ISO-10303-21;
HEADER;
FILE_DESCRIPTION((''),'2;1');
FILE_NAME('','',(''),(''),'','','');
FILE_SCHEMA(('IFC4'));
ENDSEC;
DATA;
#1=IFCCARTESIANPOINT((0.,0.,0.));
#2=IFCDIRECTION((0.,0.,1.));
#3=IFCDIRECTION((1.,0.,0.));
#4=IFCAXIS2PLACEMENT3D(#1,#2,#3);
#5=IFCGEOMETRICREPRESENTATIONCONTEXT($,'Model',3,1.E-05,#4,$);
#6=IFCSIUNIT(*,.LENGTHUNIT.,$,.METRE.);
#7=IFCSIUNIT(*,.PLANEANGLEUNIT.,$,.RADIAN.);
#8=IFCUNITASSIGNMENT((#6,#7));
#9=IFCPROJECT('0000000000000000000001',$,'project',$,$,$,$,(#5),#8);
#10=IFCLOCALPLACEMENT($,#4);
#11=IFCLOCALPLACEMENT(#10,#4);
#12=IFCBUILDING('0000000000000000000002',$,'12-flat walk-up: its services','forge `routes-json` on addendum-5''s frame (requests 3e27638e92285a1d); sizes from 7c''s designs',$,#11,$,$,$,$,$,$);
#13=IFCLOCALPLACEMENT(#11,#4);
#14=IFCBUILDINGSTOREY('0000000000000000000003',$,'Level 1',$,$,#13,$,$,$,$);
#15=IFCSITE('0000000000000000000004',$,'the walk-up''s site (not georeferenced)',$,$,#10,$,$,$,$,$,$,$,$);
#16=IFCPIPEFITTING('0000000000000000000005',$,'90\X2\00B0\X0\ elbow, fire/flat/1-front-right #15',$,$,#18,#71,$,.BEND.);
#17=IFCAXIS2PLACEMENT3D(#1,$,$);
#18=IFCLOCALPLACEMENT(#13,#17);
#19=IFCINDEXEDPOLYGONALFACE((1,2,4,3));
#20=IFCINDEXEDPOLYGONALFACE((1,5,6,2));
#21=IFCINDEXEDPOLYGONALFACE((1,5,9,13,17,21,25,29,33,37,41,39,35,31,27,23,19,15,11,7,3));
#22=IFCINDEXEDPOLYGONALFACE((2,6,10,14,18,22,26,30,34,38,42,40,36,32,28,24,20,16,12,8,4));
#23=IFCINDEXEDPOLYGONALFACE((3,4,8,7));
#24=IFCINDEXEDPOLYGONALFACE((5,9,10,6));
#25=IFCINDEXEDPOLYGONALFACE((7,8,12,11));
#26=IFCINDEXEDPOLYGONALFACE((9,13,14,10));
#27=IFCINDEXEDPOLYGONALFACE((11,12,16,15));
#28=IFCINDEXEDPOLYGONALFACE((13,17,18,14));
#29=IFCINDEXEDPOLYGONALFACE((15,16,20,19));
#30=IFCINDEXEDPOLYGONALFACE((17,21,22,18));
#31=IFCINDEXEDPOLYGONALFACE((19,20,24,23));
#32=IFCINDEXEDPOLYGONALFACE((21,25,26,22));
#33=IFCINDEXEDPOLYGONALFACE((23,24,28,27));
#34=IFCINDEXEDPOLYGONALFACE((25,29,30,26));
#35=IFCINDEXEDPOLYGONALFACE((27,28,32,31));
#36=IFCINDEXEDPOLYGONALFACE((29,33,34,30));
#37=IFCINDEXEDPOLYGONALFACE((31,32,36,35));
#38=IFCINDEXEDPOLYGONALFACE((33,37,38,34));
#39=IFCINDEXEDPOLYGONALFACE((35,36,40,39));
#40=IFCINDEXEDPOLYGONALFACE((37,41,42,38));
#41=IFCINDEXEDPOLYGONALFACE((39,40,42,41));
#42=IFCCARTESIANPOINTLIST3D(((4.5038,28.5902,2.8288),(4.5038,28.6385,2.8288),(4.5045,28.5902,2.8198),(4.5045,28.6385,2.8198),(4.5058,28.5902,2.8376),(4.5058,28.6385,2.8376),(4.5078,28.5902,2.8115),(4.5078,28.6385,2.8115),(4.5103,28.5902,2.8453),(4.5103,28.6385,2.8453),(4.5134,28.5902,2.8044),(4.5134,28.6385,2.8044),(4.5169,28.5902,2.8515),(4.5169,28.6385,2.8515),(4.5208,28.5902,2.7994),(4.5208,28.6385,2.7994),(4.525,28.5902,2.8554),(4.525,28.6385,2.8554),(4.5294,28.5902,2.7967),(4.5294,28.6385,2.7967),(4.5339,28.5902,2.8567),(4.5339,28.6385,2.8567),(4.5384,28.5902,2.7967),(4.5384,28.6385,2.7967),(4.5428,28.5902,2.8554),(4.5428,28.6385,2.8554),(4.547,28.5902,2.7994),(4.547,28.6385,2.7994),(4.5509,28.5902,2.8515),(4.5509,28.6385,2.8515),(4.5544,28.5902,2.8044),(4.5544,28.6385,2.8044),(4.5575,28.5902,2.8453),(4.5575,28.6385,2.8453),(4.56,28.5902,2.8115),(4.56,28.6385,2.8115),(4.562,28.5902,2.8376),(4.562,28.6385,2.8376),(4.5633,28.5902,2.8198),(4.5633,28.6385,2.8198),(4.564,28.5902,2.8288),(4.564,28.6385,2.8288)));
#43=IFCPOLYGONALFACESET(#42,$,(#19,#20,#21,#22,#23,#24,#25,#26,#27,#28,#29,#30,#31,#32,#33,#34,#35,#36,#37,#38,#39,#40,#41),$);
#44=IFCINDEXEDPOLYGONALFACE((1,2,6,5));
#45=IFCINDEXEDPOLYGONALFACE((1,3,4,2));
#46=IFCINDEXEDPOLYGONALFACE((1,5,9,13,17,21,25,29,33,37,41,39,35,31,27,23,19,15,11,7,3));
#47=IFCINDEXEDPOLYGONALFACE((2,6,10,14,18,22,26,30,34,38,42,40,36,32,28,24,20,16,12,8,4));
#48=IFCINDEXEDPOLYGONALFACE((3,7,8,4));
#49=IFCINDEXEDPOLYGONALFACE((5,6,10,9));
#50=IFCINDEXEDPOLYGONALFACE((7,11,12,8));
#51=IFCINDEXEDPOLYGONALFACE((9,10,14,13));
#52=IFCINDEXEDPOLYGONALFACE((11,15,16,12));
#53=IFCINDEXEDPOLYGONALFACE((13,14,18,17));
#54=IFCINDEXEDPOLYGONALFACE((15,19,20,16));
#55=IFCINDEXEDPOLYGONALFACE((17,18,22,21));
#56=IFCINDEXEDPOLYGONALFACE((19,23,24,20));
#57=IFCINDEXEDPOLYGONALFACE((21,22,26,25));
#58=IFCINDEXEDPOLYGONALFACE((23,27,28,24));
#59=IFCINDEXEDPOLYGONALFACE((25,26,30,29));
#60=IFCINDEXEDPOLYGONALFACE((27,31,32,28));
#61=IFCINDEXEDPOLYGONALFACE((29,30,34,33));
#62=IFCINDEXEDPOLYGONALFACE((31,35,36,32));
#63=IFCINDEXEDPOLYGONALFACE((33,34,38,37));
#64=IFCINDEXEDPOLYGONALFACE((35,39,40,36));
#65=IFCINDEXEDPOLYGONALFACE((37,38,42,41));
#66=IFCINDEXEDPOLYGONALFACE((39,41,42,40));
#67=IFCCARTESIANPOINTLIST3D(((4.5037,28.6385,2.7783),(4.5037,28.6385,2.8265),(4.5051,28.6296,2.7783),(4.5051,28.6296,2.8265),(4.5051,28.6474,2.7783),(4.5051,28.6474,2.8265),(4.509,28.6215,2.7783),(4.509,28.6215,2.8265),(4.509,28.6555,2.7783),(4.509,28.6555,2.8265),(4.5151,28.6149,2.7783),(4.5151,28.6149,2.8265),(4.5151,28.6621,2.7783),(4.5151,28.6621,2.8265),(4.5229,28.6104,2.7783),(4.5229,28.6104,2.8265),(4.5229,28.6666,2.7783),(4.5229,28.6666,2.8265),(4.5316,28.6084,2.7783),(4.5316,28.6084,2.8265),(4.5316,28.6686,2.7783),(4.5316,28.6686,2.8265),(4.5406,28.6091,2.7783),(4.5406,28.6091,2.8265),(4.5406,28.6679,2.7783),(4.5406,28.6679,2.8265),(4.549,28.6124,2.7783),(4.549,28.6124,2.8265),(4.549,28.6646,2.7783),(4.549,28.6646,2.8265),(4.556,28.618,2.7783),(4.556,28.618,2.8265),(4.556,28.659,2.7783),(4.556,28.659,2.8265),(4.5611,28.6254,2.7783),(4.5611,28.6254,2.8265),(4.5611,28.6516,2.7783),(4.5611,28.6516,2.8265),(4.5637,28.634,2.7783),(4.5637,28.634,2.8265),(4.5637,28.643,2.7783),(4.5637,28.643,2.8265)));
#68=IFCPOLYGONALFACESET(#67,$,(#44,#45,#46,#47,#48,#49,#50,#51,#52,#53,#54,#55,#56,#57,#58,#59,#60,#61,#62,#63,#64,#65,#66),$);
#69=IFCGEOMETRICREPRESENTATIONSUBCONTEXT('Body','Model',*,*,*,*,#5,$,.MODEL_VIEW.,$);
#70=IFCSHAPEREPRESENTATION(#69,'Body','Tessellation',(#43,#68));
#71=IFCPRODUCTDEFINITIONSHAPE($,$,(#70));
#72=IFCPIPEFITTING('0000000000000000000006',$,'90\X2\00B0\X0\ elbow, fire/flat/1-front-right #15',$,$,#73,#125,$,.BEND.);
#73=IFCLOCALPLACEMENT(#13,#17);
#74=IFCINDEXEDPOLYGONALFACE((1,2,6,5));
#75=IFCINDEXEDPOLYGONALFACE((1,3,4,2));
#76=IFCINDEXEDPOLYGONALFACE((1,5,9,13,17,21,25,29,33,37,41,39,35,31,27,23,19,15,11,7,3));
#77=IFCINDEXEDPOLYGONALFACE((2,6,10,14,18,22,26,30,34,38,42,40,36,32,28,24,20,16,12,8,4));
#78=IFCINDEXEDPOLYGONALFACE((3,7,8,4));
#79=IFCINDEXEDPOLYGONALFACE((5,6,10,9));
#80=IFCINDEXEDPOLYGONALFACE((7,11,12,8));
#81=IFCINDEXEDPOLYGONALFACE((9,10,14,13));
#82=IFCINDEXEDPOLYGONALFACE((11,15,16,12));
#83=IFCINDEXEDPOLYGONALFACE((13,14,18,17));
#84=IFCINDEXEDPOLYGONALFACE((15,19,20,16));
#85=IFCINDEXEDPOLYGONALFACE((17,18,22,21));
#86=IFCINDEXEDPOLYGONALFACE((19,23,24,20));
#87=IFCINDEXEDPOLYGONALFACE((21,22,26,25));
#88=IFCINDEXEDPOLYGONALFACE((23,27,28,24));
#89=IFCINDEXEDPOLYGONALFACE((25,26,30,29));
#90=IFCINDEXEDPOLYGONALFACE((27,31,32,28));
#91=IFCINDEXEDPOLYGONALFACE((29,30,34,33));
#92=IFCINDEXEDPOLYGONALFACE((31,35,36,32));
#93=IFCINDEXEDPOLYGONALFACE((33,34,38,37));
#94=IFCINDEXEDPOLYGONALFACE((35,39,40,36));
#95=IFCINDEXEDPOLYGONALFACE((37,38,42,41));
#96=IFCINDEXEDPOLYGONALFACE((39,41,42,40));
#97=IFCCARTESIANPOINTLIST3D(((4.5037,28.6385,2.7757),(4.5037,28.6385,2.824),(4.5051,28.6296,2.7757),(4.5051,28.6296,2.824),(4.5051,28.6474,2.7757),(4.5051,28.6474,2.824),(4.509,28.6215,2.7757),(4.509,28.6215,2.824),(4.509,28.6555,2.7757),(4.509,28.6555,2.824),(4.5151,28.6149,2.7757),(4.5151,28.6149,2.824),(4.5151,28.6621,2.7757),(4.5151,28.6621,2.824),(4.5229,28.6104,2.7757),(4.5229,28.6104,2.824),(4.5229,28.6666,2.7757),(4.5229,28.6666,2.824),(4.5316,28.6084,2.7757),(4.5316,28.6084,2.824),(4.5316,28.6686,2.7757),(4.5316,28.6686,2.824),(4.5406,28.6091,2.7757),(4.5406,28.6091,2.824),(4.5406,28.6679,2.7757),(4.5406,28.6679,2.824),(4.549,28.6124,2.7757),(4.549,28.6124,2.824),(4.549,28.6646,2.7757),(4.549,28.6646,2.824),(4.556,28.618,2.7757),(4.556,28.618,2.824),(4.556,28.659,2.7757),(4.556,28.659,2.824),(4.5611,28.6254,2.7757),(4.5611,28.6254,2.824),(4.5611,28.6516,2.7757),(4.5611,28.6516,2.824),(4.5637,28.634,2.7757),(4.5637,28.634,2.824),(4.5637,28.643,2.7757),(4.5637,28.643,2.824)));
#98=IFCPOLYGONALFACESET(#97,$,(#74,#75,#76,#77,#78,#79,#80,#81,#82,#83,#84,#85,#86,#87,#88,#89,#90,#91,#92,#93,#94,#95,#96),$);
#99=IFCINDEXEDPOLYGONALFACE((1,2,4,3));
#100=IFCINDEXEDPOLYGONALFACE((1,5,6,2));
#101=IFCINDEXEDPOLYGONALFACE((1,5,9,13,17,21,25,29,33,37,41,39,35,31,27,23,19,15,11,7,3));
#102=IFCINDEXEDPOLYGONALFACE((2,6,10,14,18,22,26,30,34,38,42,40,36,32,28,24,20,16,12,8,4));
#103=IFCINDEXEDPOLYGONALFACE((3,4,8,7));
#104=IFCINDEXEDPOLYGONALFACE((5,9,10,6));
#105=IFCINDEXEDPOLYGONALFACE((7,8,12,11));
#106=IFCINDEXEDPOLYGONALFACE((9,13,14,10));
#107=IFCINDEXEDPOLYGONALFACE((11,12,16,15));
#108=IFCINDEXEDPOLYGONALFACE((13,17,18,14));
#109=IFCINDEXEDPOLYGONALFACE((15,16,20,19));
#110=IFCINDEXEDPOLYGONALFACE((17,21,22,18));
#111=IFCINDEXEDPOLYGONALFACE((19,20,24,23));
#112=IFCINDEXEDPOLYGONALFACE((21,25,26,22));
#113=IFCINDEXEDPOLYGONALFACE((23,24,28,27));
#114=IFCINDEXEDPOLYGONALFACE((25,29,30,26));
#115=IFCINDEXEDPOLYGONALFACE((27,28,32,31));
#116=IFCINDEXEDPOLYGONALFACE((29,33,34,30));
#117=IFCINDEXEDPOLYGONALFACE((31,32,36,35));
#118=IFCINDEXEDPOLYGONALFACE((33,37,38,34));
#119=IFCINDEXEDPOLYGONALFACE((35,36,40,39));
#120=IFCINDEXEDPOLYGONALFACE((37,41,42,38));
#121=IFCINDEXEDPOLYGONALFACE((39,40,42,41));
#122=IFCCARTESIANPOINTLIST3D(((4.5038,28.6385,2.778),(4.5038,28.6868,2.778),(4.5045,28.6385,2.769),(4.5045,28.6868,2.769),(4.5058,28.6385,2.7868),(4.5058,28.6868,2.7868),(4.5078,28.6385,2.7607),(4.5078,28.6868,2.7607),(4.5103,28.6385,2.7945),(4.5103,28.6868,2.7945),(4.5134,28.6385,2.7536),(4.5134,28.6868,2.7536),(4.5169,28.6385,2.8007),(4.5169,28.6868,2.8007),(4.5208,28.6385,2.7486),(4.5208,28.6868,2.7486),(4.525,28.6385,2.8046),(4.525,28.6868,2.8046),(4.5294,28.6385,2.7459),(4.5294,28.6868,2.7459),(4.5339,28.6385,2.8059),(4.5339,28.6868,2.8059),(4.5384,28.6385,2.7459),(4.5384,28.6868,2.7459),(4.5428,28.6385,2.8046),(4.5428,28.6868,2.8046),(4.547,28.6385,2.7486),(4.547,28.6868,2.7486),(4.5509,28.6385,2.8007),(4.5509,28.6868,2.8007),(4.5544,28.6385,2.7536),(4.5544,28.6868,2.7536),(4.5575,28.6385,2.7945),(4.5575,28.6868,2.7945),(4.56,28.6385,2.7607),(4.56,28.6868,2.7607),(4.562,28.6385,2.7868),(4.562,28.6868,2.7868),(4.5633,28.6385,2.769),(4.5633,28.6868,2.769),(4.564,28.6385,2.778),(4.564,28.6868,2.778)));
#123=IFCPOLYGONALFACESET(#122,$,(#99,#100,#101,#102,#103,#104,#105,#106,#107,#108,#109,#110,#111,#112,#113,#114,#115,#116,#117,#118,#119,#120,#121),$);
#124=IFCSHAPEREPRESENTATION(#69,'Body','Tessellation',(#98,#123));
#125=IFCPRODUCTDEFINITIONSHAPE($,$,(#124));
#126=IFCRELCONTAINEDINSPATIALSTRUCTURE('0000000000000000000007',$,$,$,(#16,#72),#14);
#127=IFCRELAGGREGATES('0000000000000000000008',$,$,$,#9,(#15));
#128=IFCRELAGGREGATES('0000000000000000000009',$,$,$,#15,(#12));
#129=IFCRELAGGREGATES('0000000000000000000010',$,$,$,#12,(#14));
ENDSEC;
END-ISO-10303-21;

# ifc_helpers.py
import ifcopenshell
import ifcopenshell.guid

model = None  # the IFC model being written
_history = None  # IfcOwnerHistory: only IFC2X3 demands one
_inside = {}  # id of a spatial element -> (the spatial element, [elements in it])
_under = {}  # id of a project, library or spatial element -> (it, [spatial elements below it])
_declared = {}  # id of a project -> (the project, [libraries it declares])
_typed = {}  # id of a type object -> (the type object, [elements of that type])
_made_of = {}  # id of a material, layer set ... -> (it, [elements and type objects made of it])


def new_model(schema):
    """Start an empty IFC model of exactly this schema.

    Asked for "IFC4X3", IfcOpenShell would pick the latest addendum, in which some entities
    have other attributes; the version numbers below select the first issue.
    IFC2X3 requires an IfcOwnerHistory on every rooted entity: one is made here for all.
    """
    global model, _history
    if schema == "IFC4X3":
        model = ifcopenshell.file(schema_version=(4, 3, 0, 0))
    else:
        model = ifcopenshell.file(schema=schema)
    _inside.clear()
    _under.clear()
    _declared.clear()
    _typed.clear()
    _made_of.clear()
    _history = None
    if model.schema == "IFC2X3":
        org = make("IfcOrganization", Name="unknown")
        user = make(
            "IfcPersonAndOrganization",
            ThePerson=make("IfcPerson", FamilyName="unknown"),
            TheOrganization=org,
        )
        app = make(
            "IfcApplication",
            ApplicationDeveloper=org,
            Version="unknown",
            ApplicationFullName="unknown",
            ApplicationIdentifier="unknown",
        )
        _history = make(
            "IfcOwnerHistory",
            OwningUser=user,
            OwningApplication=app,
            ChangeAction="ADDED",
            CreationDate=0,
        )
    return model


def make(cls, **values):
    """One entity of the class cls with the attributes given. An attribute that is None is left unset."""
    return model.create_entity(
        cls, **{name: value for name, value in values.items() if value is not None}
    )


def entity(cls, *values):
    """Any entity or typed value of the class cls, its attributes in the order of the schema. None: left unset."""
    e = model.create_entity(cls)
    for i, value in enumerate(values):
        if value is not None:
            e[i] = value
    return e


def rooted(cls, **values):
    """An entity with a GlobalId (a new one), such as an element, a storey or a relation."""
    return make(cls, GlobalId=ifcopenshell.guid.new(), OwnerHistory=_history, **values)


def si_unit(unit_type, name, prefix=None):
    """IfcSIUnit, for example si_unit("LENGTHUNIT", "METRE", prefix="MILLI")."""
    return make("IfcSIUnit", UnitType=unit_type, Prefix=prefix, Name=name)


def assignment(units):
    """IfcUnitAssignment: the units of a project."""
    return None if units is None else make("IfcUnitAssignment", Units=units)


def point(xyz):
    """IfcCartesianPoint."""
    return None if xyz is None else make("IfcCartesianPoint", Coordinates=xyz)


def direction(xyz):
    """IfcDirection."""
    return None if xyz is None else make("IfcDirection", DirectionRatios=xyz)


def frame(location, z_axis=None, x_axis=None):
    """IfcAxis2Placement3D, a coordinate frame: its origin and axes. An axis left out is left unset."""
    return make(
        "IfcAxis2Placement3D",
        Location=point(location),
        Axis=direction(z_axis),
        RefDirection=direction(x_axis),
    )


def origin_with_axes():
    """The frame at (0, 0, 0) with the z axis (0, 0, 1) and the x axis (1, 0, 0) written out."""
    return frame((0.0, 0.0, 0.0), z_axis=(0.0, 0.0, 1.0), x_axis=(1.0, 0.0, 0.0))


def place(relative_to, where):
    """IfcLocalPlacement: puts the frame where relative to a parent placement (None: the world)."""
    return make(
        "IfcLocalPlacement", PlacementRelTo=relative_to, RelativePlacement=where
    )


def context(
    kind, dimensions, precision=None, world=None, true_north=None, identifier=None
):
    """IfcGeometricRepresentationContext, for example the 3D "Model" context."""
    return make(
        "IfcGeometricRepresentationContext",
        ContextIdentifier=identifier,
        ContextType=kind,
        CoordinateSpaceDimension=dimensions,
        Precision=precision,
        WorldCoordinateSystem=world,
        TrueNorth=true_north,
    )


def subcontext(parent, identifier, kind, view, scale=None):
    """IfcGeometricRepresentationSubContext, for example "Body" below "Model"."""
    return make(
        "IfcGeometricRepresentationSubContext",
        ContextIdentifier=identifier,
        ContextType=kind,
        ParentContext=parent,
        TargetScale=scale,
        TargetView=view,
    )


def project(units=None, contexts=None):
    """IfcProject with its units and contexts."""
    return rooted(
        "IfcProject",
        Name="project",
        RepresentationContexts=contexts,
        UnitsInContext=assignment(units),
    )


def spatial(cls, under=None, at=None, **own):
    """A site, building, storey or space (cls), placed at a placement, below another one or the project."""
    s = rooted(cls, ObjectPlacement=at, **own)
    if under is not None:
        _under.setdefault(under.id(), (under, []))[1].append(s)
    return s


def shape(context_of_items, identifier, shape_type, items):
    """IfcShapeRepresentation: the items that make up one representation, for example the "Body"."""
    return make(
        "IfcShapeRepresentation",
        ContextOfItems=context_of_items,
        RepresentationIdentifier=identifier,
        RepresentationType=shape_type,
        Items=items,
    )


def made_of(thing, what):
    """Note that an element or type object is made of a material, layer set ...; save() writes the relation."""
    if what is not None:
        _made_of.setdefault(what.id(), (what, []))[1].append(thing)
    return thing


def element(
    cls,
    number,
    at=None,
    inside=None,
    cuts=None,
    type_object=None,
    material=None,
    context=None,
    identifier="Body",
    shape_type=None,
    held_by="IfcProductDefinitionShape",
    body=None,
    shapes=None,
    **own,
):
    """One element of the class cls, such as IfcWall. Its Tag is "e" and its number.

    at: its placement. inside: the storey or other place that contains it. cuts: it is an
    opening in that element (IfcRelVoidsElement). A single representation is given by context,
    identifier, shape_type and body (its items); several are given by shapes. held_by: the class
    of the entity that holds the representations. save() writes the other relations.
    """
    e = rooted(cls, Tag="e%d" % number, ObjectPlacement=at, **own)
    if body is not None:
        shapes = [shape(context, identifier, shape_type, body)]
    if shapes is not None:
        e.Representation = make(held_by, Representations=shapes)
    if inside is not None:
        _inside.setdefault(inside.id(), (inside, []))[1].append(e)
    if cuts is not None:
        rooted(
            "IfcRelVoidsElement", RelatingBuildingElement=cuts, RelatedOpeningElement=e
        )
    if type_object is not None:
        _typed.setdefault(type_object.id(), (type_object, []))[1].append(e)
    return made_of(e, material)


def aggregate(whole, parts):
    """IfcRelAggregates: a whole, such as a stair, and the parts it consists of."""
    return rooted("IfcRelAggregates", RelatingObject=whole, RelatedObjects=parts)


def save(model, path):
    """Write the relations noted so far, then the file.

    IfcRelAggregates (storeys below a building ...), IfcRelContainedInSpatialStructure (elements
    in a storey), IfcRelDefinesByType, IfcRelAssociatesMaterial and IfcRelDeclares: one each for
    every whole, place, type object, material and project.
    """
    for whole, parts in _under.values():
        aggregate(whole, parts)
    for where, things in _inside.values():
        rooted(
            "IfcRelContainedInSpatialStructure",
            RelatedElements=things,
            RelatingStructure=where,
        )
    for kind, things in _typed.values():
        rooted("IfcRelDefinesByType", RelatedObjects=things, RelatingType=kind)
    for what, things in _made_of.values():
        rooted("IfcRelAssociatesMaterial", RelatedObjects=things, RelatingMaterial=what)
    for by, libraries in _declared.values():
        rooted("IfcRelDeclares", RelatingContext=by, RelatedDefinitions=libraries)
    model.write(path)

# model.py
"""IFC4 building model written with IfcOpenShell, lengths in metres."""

from ifc_helpers import new_model, entity, si_unit, frame, origin_with_axes, place, context, subcontext, project, spatial, element, save


model = new_model("IFC4")

# Units and contexts
model_context = context("Model", 3, precision=1e-05, world=origin_with_axes())
body_context = subcontext(model_context, "Body", "Model", "MODEL_VIEW")
ifc_project = project(units=[si_unit("LENGTHUNIT", "METRE"), si_unit("PLANEANGLEUNIT", "RADIAN")], contexts=[model_context])

# Site, building, storey
site_placement = place(None, origin_with_axes())
site = spatial("IfcSite", under=ifc_project, at=site_placement, Name="the walk-up's site (not georeferenced)")
building_placement = place(site_placement, origin_with_axes())
building = spatial("IfcBuilding", under=site, at=building_placement, Name="12-flat walk-up: its services", Description="forge `routes-json` on addendum-5's frame (requests 3e27638e92285a1d); sizes from 7c's designs")
storey_placement = place(building_placement, origin_with_axes())
storey = spatial("IfcBuildingStorey", under=building, at=storey_placement, Name="Level 1")

# Pipe fittings
pipe_fitting_1_placement = place(storey_placement, frame((4.5339, 28.5902, 2.8265), z_axis=(0.0, 0.0, 1.0), x_axis=(1.0, 0.0, 0.0)))
element("IfcPipeFitting", 1, at=pipe_fitting_1_placement, inside=storey, Name="90° elbow, fire/flat/1-front-right #15", PredefinedType="BEND", context=body_context, shape_type="AdvancedSweptSolid", body=[
    entity("IfcSweptDiskSolid", entity("IfcPolyline", [entity("IfcCartesianPoint", [0.0, 0.0, 0.0]), entity("IfcCartesianPoint", [0.0, 0.0483, 0.0])]), 0.0302),
    entity("IfcSweptDiskSolid", entity("IfcPolyline", [entity("IfcCartesianPoint", [0.0, 0.0483, 0.0]), entity("IfcCartesianPoint", [0.0, 0.0483, -0.0483])]), 0.0302),
])
pipe_fitting_2_placement = place(storey_placement, frame((4.5339, 28.6385, 2.824), z_axis=(0.0, 0.0, 1.0), x_axis=(1.0, 0.0, 0.0)))
element("IfcPipeFitting", 2, at=pipe_fitting_2_placement, inside=storey, Name="90° elbow, fire/flat/1-front-right #15", PredefinedType="BEND", context=body_context, shape_type="AdvancedSweptSolid", body=[
    entity("IfcSweptDiskSolid", entity("IfcPolyline", [entity("IfcCartesianPoint", [0.0, 0.0, 0.0]), entity("IfcCartesianPoint", [0.0, 0.0, -0.0483])]), 0.0302),
    entity("IfcSweptDiskSolid", entity("IfcPolyline", [entity("IfcCartesianPoint", [0.0, 0.0, -0.0483]), entity("IfcCartesianPoint", [0.0, 0.0483, -0.0483])]), 0.0302),
])

save(model, "model.ifc")
